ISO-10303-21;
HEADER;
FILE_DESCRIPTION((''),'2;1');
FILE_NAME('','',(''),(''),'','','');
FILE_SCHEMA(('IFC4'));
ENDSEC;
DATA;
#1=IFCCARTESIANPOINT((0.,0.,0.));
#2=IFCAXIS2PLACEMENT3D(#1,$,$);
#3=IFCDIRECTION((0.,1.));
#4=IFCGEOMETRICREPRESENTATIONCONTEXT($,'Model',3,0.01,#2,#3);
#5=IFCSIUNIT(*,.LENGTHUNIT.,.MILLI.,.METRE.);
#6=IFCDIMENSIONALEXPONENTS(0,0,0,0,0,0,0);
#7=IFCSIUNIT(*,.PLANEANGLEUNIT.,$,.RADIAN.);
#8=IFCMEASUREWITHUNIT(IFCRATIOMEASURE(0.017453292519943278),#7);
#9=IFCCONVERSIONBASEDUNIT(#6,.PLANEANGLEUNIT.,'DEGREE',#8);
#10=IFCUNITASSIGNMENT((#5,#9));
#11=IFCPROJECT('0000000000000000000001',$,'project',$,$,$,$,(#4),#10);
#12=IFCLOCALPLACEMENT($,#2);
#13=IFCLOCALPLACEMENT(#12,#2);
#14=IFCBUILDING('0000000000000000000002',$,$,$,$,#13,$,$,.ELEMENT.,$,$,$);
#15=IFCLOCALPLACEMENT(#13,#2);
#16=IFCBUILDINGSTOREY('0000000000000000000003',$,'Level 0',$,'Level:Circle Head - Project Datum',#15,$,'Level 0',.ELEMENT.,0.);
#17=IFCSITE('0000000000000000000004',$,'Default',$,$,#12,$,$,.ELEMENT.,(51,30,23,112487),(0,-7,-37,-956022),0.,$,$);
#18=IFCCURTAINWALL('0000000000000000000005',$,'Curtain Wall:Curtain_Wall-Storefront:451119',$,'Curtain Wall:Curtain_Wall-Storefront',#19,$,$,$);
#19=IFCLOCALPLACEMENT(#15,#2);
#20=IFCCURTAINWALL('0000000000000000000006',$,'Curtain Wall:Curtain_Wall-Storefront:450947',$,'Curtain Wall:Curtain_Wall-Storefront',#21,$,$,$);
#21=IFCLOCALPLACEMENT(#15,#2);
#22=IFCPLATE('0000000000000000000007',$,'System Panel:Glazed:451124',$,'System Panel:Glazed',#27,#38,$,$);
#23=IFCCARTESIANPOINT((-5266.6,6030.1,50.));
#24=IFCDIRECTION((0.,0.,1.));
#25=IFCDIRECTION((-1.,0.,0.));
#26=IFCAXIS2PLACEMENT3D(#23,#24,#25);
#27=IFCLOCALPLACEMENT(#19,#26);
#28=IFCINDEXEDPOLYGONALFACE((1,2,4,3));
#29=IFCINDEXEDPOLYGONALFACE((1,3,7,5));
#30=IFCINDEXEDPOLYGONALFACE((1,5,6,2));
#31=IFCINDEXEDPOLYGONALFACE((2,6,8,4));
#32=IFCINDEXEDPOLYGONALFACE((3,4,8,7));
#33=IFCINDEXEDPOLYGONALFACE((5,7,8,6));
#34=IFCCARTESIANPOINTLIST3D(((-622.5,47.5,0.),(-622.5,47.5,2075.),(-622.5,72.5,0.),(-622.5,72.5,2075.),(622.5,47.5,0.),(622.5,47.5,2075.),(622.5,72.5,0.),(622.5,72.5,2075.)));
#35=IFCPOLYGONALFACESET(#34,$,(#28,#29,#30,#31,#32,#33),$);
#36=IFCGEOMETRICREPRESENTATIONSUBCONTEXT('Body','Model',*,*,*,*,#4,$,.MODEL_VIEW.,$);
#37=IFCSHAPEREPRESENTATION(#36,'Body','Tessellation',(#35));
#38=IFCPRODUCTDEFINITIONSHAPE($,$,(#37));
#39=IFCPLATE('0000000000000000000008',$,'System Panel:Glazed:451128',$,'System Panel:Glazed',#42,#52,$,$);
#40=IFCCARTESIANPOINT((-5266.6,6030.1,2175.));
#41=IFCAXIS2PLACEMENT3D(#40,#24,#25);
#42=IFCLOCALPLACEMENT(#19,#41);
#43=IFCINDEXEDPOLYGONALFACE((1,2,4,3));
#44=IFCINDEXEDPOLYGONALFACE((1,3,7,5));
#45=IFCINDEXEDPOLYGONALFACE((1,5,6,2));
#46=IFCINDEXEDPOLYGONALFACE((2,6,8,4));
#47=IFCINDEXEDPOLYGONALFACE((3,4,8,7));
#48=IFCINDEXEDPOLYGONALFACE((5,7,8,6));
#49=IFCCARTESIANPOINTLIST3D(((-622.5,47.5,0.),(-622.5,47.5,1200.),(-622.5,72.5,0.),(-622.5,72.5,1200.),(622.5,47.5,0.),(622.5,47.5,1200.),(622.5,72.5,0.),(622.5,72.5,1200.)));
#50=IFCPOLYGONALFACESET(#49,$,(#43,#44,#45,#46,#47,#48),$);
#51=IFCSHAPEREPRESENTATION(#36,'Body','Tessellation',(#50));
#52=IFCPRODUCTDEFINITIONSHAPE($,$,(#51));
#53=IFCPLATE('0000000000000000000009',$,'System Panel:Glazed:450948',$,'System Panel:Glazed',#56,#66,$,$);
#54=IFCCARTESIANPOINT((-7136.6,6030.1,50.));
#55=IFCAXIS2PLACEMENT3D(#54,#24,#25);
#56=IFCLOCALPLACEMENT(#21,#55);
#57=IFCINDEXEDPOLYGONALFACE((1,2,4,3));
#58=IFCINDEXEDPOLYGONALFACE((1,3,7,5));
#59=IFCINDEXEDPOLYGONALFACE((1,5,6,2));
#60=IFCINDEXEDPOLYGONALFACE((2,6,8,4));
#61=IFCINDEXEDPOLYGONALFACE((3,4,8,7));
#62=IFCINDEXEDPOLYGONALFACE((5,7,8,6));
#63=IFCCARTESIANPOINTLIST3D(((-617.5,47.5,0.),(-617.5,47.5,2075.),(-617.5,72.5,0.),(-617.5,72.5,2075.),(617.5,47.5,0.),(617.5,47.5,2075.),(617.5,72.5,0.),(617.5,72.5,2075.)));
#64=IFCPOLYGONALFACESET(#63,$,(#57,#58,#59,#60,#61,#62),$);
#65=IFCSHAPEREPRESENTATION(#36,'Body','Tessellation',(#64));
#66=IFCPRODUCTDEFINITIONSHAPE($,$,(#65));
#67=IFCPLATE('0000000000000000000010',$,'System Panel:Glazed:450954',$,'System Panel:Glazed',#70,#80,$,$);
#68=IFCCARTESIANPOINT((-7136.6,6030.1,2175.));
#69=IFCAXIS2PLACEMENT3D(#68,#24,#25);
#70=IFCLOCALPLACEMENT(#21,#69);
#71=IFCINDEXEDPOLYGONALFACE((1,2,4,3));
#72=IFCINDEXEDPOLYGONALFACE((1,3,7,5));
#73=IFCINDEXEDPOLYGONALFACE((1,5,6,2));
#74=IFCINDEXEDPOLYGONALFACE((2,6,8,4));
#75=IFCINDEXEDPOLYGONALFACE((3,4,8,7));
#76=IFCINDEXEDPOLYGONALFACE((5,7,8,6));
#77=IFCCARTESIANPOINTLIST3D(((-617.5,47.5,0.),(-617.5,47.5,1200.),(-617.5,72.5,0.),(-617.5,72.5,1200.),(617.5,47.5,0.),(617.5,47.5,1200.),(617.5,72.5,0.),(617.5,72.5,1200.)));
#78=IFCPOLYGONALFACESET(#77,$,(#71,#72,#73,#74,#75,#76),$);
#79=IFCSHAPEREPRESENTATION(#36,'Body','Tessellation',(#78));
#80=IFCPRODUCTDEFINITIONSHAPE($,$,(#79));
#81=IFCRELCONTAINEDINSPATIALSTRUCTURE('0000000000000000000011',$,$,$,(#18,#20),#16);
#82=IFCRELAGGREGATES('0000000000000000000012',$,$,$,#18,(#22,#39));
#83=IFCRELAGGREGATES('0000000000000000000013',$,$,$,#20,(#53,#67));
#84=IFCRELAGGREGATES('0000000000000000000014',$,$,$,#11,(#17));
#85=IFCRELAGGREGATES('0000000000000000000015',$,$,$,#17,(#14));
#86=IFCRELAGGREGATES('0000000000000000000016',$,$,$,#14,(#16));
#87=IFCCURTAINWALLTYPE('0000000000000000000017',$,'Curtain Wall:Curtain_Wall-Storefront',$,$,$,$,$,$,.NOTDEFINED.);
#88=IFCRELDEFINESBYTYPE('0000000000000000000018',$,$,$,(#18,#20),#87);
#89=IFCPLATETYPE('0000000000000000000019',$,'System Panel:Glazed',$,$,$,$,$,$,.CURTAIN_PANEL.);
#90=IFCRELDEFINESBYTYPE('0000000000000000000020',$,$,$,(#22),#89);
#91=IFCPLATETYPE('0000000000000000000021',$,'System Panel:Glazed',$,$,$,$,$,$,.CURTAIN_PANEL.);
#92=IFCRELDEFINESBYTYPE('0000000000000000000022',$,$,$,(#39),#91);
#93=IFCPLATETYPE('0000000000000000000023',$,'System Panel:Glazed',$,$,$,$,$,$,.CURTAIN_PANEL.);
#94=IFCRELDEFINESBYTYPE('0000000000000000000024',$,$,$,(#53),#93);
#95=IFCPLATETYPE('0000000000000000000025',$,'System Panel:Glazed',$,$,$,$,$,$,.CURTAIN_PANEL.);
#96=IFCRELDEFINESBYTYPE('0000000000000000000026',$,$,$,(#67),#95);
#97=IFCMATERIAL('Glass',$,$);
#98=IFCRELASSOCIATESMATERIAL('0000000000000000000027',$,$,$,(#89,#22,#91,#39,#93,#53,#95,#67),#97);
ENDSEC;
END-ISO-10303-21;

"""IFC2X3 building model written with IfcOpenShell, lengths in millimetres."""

from ifc_helpers import new_model, entity, si_unit, converted_unit, direction, frame, origin, origin_2d_with_axis, place, context, subcontext, project, spatial, rectangle, extrude, source, transform, mapped, material, type_object, type_shapes, element, aggregate, save


model = new_model("IFC2X3")

# Units and contexts
model_context = context("Model", 3, precision=0.01, world=origin(), true_north=direction((0.0, 1.0)))
body_context = subcontext(model_context, "Body", "Model", "MODEL_VIEW")
ifc_project = project(units=[si_unit("LENGTHUNIT", "METRE", prefix="MILLI"), converted_unit("PLANEANGLEUNIT", "DEGREE", entity("IfcRatioMeasure", 0.017453292519943278), si_unit("PLANEANGLEUNIT", "RADIAN"), dimensions=[0, 0, 0, 0, 0, 0, 0])], contexts=[model_context])

# Site, building, storey
site_placement = place(None, origin())
site = spatial("IfcSite", under=ifc_project, at=site_placement, Name="Default", CompositionType="ELEMENT", RefLatitude=(51, 30, 23, 112487), RefLongitude=(0, -7, -37, -956022), RefElevation=0.0)
building_placement = place(site_placement, origin())
building = spatial("IfcBuilding", under=site, at=building_placement, CompositionType="ELEMENT")
storey_placement = place(building_placement, origin())
storey = spatial("IfcBuildingStorey", under=building, at=storey_placement, Name="Level 0", ObjectType="Level:Circle Head - Project Datum", LongName="Level 0", CompositionType="ELEMENT", Elevation=0.0)

# Curtain walls
curtain_wall_type = type_object("IfcCurtainWallType", Name="Curtain Wall:Curtain_Wall-Storefront", PredefinedType="NOTDEFINED")
curtain_wall_1_placement = place(storey_placement, origin())
curtain_wall_1 = element("IfcCurtainWall", 1, at=curtain_wall_1_placement, inside=storey, type_object=curtain_wall_type, Name="Curtain Wall:Curtain_Wall-Storefront:451119", ObjectType="Curtain Wall:Curtain_Wall-Storefront")
curtain_wall_2_placement = place(storey_placement, origin())
curtain_wall_2 = element("IfcCurtainWall", 2, at=curtain_wall_2_placement, inside=storey, type_object=curtain_wall_type, Name="Curtain Wall:Curtain_Wall-Storefront:450947", ObjectType="Curtain Wall:Curtain_Wall-Storefront")

# Plates
ifc_material_1 = material(Name="Glass")
plate_type_1 = type_object("IfcPlateType", Name="System Panel:Glazed", PredefinedType="CURTAIN_PANEL", material=ifc_material_1)
shared_shape_1 = source(origin(), body_context, "Body", "SweptSolid", [
    extrude(rectangle(XDim=25.0, YDim=1245.0, at=origin_2d_with_axis()), frame((0.0, 60.0, 0.0), z_axis=(0.0, 0.0, 1.0), x_axis=(0.0, 1.0, 0.0)), (0.0, 0.0, 1.0), 2075.0),
])
type_shapes(plate_type_1, [shared_shape_1])
plate_1_placement = place(curtain_wall_1_placement, frame((-5266.6, 6030.1, 50.0), z_axis=(0.0, 0.0, 1.0), x_axis=(-1.0, 0.0, 0.0)))
plate_1 = element("IfcPlate", 3, at=plate_1_placement, type_object=plate_type_1, material=ifc_material_1, Name="System Panel:Glazed:451124", ObjectType="System Panel:Glazed", context=body_context, shape_type="MappedRepresentation", body=[
    mapped(shared_shape_1, transform((0.0, 0.0, 0.0), scale=1.0)),
])
plate_type_2 = type_object("IfcPlateType", Name="System Panel:Glazed", PredefinedType="CURTAIN_PANEL", material=ifc_material_1)
shared_shape_2 = source(origin(), body_context, "Body", "SweptSolid", [
    extrude(rectangle(XDim=25.0, YDim=1245.0, at=origin_2d_with_axis()), frame((0.0, 60.0, 0.0), z_axis=(0.0, 0.0, 1.0), x_axis=(0.0, 1.0, 0.0)), (0.0, 0.0, 1.0), 1200.0),
])
type_shapes(plate_type_2, [shared_shape_2])
plate_2_placement = place(curtain_wall_1_placement, frame((-5266.6, 6030.1, 2175.0), z_axis=(0.0, 0.0, 1.0), x_axis=(-1.0, 0.0, 0.0)))
plate_2 = element("IfcPlate", 4, at=plate_2_placement, type_object=plate_type_2, material=ifc_material_1, Name="System Panel:Glazed:451128", ObjectType="System Panel:Glazed", context=body_context, shape_type="MappedRepresentation", body=[
    mapped(shared_shape_2, transform((0.0, 0.0, 0.0), scale=1.0)),
])
aggregate(curtain_wall_1, [plate_1, plate_2])
plate_type_3 = type_object("IfcPlateType", Name="System Panel:Glazed", PredefinedType="CURTAIN_PANEL", material=ifc_material_1)
shared_shape_3 = source(origin(), body_context, "Body", "SweptSolid", [
    extrude(rectangle(XDim=25.0, YDim=1235.0, at=origin_2d_with_axis()), frame((0.0, 60.0, 0.0), z_axis=(0.0, 0.0, 1.0), x_axis=(0.0, 1.0, 0.0)), (0.0, 0.0, 1.0), 2075.0),
])
type_shapes(plate_type_3, [shared_shape_3])
plate_3_placement = place(curtain_wall_2_placement, frame((-7136.6, 6030.1, 50.0), z_axis=(0.0, 0.0, 1.0), x_axis=(-1.0, 0.0, 0.0)))
plate_3 = element("IfcPlate", 5, at=plate_3_placement, type_object=plate_type_3, material=ifc_material_1, Name="System Panel:Glazed:450948", ObjectType="System Panel:Glazed", context=body_context, shape_type="MappedRepresentation", body=[
    mapped(shared_shape_3, transform((0.0, 0.0, 0.0), scale=1.0)),
])
plate_type_4 = type_object("IfcPlateType", Name="System Panel:Glazed", PredefinedType="CURTAIN_PANEL", material=ifc_material_1)
shared_shape_4 = source(origin(), body_context, "Body", "SweptSolid", [
    extrude(rectangle(XDim=25.0, YDim=1235.0, at=origin_2d_with_axis()), frame((0.0, 60.0, 0.0), z_axis=(0.0, 0.0, 1.0), x_axis=(0.0, 1.0, 0.0)), (0.0, 0.0, 1.0), 1200.0),
])
type_shapes(plate_type_4, [shared_shape_4])
plate_4_placement = place(curtain_wall_2_placement, frame((-7136.6, 6030.1, 2175.0), z_axis=(0.0, 0.0, 1.0), x_axis=(-1.0, 0.0, 0.0)))
plate_4 = element("IfcPlate", 6, at=plate_4_placement, type_object=plate_type_4, material=ifc_material_1, Name="System Panel:Glazed:450954", ObjectType="System Panel:Glazed", context=body_context, shape_type="MappedRepresentation", body=[
    mapped(shared_shape_4, transform((0.0, 0.0, 0.0), scale=1.0)),
])
aggregate(curtain_wall_2, [plate_3, plate_4])

save(model, "model.ifc")
